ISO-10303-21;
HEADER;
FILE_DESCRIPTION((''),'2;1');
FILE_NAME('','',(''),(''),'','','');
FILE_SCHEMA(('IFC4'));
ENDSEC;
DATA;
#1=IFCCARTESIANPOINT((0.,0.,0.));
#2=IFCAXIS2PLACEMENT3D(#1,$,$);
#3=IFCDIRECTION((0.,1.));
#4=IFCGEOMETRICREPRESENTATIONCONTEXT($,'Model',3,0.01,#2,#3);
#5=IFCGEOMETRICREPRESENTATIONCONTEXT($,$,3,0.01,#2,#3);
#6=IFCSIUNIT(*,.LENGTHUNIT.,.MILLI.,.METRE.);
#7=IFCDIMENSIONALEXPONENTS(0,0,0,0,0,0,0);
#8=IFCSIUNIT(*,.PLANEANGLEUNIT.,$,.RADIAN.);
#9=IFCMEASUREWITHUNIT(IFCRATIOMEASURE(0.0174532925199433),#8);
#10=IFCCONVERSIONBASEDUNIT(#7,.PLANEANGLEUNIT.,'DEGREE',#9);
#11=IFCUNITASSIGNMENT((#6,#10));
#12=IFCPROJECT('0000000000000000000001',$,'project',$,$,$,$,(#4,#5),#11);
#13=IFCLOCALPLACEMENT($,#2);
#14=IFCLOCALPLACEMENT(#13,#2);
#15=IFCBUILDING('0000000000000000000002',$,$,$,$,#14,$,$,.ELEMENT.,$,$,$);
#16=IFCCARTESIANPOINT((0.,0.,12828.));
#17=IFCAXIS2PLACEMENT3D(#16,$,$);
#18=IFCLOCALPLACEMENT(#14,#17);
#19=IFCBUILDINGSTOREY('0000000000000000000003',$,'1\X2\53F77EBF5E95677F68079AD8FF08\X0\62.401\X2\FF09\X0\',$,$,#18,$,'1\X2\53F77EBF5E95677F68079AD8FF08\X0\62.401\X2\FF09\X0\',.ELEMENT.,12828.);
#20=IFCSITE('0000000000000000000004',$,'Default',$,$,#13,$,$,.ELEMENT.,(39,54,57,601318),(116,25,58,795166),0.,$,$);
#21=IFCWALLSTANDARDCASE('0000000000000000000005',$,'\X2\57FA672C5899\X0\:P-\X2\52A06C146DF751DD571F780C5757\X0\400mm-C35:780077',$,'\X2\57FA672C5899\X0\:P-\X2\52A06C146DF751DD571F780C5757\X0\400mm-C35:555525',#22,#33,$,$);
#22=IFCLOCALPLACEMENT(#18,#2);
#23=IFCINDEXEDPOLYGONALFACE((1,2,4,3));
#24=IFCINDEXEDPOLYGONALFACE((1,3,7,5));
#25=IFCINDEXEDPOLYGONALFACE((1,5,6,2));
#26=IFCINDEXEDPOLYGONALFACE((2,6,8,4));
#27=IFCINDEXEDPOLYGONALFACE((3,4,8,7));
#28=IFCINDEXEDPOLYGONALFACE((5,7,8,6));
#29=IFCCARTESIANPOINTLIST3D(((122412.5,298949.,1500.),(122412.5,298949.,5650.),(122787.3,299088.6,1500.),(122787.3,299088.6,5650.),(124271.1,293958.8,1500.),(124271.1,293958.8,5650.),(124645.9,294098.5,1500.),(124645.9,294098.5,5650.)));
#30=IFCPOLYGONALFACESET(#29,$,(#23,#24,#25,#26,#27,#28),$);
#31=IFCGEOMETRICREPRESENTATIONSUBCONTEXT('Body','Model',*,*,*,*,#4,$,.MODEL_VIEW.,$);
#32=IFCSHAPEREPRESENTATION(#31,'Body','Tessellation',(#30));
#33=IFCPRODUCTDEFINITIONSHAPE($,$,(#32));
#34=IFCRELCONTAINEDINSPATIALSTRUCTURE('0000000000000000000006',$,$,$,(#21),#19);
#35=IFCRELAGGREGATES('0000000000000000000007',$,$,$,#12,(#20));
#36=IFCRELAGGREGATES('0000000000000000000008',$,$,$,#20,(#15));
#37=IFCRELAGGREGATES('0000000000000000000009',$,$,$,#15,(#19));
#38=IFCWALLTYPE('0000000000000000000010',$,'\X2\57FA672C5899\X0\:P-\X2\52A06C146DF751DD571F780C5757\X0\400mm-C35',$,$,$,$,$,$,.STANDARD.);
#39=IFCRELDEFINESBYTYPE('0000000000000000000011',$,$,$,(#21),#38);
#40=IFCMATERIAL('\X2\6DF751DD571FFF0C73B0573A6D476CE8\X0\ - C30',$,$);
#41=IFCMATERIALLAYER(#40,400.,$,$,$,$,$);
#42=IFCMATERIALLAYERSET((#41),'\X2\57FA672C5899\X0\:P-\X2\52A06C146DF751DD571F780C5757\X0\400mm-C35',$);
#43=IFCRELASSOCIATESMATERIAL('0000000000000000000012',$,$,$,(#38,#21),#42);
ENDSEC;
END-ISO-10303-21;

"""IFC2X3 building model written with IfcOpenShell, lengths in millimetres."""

from ifc_helpers import new_model, entity, si_unit, converted_unit, direction, frame, frame_2d, origin, place, context, subcontext, project, spatial, polyline, rectangle, extrude, clip, bounded_halfspace, material, layer, layer_set, layer_usage, type_object, element, save


model = new_model("IFC2X3")

# Units and contexts
model_context = context("Model", 3, precision=0.01, world=origin(), true_north=direction((0.0, 1.0)))
context_of_model = context(None, 3, precision=0.01, world=origin(), true_north=direction((0.0, 1.0)))
body_context = subcontext(model_context, "Body", "Model", "MODEL_VIEW")
ifc_project = project(units=[si_unit("LENGTHUNIT", "METRE", prefix="MILLI"), converted_unit("PLANEANGLEUNIT", "DEGREE", entity("IfcRatioMeasure", 0.0174532925199433), si_unit("PLANEANGLEUNIT", "RADIAN"), dimensions=[0, 0, 0, 0, 0, 0, 0])], contexts=[model_context, context_of_model])

# Site, building, storey
site_placement = place(None, origin())
site = spatial("IfcSite", under=ifc_project, at=site_placement, Name="Default", CompositionType="ELEMENT", RefLatitude=(39, 54, 57, 601318), RefLongitude=(116, 25, 58, 795166), RefElevation=0.0)
building_placement = place(site_placement, origin())
building = spatial("IfcBuilding", under=site, at=building_placement, CompositionType="ELEMENT")
storey_placement = place(building_placement, frame((0.0, 0.0, 12828.0)))
storey = spatial("IfcBuildingStorey", under=building, at=storey_placement, Name="1号线底板标高（62.401）", LongName="1号线底板标高（62.401）", CompositionType="ELEMENT", Elevation=12828.0)

# Wall
ifc_material_1 = material(Name="混凝土，现场浇注 - C30")
ifc_layer_1 = layer(ifc_material_1, 400.0)
ifc_layer_set_1 = layer_set([ifc_layer_1], Name="基本墙:P-加气混凝土砌块400mm-C35")
wall_type_1 = type_object("IfcWallType", Name="基本墙:P-加气混凝土砌块400mm-C35", PredefinedType="STANDARD", material=ifc_layer_set_1)
ifc_layer_usage_1 = layer_usage(ifc_layer_set_1, "AXIS2", "NEGATIVE", 200.0)
wall_1_placement = place(storey_placement, frame((122599.9, 299018.8, 1500.0), z_axis=(0.0, 0.0, 1.0), x_axis=(0.349028, -0.937112, 0.0)))
element("IfcWallStandardCase", 1, at=wall_1_placement, inside=storey, type_object=wall_type_1, material=ifc_layer_usage_1, Name="基本墙:P-加气混凝土砌块400mm-C35:780077", ObjectType="基本墙:P-加气混凝土砌块400mm-C35:555525", context=body_context, shape_type="Clipping", body=[
    clip(extrude(rectangle(XDim=5325.0, YDim=400.0, at=frame_2d((2662.5, 0.0), x_axis=(-1.0, 0.0))), origin(), (0.0, 0.0, 1.0), 4150.0), bounded_halfspace(frame((0.0, -200.0, 4150.0), z_axis=(0.0, 0.0, -1.0), x_axis=(0.0, 1.0, 0.0)), True, frame((0.0, -200.0, 4150.0)), polyline([(0.0, 0.0), (5325.0, 0.0), (5325.0, 400.0), (1800.0, 400.0), (1700.0, 400.0), (0.0, 400.0), (0.0, 0.0)]))),
])

save(model, "model.ifc")
